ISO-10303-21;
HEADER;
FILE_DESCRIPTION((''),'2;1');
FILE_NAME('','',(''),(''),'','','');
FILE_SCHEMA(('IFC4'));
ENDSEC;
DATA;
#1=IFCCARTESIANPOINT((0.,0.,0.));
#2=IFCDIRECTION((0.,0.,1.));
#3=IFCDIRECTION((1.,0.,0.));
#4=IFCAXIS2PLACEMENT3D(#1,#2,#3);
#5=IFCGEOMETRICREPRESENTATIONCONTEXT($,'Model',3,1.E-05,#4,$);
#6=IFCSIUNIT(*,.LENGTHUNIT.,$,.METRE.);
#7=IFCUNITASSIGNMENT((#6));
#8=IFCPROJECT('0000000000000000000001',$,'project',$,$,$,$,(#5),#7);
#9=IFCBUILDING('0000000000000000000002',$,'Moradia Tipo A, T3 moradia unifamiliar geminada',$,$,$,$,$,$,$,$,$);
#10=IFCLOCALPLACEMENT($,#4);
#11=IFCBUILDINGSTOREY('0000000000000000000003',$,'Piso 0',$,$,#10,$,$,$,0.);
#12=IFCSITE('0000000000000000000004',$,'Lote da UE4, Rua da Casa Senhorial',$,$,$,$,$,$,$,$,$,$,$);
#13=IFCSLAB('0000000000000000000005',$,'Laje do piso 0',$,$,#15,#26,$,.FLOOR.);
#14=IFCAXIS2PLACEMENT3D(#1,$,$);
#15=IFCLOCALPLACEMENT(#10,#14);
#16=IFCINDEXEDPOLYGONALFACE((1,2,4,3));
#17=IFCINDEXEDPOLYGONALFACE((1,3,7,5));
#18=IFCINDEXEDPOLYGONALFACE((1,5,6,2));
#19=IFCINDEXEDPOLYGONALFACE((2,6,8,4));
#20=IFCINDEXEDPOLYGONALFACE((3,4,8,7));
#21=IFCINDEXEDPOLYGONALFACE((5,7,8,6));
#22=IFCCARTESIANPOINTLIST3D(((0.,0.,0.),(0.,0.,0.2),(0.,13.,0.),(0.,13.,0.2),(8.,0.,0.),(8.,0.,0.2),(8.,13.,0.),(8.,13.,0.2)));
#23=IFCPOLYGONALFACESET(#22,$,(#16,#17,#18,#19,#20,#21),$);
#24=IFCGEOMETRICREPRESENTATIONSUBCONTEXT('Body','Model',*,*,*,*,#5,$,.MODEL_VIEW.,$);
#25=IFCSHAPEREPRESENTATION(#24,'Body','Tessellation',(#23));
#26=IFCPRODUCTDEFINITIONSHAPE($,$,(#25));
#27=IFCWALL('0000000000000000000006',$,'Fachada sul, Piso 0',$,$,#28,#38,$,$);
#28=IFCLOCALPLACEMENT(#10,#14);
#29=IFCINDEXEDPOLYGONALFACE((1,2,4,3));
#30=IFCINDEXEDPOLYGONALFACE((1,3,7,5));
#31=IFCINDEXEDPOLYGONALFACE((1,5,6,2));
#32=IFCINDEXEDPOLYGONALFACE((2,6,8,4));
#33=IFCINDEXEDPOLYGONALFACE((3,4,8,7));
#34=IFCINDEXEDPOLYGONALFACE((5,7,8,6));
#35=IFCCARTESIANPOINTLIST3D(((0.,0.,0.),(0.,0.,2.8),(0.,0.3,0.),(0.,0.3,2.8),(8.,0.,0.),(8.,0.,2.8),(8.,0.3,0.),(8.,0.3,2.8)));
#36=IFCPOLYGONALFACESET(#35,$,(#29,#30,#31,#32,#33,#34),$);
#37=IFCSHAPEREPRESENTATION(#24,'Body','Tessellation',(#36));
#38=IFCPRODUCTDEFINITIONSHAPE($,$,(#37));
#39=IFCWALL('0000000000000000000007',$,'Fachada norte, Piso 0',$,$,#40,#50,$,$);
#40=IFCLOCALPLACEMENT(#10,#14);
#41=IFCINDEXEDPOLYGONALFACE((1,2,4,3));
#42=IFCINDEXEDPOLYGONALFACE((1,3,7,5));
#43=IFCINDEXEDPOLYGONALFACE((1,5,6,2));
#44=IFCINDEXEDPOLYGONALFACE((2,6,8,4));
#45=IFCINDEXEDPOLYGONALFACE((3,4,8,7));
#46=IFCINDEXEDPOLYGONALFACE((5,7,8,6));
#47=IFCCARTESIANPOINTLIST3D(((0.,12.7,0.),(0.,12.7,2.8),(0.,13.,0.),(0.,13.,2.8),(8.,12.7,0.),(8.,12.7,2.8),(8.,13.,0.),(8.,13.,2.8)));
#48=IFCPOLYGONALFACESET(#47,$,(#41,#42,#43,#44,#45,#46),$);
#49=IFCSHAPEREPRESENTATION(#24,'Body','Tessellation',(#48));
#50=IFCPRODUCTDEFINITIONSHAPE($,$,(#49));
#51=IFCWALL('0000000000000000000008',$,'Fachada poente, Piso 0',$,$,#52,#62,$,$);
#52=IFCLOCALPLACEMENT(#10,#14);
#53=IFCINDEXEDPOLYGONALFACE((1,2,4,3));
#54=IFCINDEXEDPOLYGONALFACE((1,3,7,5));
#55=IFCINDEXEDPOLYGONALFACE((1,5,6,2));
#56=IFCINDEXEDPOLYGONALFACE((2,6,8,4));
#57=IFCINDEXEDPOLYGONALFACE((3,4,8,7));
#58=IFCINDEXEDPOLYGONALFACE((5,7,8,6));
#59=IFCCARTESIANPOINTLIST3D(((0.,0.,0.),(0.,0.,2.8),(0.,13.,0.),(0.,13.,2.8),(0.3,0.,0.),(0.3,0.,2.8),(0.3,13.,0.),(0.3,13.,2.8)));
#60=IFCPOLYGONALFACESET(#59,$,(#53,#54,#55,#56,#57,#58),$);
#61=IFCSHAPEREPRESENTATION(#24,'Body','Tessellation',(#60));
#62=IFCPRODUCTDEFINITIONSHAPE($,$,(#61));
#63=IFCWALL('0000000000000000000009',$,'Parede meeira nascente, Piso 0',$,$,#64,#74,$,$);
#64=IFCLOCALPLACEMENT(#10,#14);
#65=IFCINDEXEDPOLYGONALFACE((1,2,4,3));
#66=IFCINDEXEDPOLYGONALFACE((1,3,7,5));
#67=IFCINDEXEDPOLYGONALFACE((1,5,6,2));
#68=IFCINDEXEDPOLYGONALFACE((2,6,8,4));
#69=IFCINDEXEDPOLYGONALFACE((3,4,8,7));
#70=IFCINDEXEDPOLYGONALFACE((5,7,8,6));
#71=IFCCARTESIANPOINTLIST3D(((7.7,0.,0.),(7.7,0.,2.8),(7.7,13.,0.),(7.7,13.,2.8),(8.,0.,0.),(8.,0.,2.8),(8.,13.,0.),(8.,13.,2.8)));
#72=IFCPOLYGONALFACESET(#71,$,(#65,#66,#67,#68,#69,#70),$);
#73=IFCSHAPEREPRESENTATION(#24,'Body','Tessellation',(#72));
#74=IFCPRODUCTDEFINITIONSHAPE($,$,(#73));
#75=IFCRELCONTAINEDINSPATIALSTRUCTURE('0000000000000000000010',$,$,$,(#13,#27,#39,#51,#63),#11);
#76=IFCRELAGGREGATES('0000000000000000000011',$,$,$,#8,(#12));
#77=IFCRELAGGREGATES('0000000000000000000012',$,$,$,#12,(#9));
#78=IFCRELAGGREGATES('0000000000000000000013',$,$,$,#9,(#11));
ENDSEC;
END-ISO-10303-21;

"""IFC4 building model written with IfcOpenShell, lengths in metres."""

from ifc_helpers import new_model, si_unit, frame, origin_with_axes, place, context, subcontext, project, spatial, indexed_curve, outline, extrude, element, save


model = new_model("IFC4")

# Units and contexts
model_context = context("Model", 3, precision=1e-05, world=origin_with_axes())
body_context = subcontext(model_context, "Body", "Model", "MODEL_VIEW")
ifc_project = project(units=[si_unit("LENGTHUNIT", "METRE")], contexts=[model_context])

# Site, building, storey
site = spatial("IfcSite", under=ifc_project, Name="Lote da UE4, Rua da Casa Senhorial")
building = spatial("IfcBuilding", under=site, Name="Moradia Tipo A, T3 moradia unifamiliar geminada")
storey_placement = place(None, origin_with_axes())
storey = spatial("IfcBuildingStorey", under=building, at=storey_placement, Name="Piso 0", Elevation=0.0)

# Slab
slab_placement = place(storey_placement, origin_with_axes())
element("IfcSlab", 1, at=slab_placement, inside=storey, Name="Laje do piso 0", PredefinedType="FLOOR", context=body_context, shape_type="SweptSolid", body=[
    extrude(outline(indexed_curve([(0.0, 0.0), (8.0, 0.0), (8.0, 13.0), (0.0, 13.0), (0.0, 0.0)])), None, (0.0, 0.0, 1.0), 0.2),
])

# Walls
for number, where, z_axis, x_axis, name in (
    (2, (0.0, 0.0, 0.0), (0.0, 0.0, 1.0), (1.0, 0.0, 0.0), "Fachada sul, Piso 0"),
    (3, (0.0, 12.7, 0.0), (0.0, 0.0, 1.0), (1.0, 0.0, 0.0), "Fachada norte, Piso 0"),
):
    element("IfcWall", number, at=place(storey_placement, frame(where, z_axis=z_axis, x_axis=x_axis)), inside=storey, Name=name, context=body_context, shape_type="SweptSolid", body=[
        extrude(outline(indexed_curve([(0.0, 0.0), (0.0, 0.3), (8.0, 0.3), (8.0, 0.0), (0.0, 0.0)], self_intersect=False)), origin_with_axes(), (0.0, 0.0, 1.0), 2.8),
    ])
for number, where, z_axis, x_axis, name in (
    (4, (0.3, 0.0, 0.0), (0.0, 0.0, 1.0), (0.0, 1.0, 0.0), "Fachada poente, Piso 0"),
    (5, (8.0, 0.0, 0.0), (0.0, 0.0, 1.0), (0.0, 1.0, 0.0), "Parede meeira nascente, Piso 0"),
):
    element("IfcWall", number, at=place(storey_placement, frame(where, z_axis=z_axis, x_axis=x_axis)), inside=storey, Name=name, context=body_context, shape_type="SweptSolid", body=[
        extrude(outline(indexed_curve([(0.0, 0.0), (0.0, 0.3), (13.0, 0.3), (13.0, 0.0), (0.0, 0.0)], self_intersect=False)), origin_with_axes(), (0.0, 0.0, 1.0), 2.8),
    ])

save(model, "model.ifc")
